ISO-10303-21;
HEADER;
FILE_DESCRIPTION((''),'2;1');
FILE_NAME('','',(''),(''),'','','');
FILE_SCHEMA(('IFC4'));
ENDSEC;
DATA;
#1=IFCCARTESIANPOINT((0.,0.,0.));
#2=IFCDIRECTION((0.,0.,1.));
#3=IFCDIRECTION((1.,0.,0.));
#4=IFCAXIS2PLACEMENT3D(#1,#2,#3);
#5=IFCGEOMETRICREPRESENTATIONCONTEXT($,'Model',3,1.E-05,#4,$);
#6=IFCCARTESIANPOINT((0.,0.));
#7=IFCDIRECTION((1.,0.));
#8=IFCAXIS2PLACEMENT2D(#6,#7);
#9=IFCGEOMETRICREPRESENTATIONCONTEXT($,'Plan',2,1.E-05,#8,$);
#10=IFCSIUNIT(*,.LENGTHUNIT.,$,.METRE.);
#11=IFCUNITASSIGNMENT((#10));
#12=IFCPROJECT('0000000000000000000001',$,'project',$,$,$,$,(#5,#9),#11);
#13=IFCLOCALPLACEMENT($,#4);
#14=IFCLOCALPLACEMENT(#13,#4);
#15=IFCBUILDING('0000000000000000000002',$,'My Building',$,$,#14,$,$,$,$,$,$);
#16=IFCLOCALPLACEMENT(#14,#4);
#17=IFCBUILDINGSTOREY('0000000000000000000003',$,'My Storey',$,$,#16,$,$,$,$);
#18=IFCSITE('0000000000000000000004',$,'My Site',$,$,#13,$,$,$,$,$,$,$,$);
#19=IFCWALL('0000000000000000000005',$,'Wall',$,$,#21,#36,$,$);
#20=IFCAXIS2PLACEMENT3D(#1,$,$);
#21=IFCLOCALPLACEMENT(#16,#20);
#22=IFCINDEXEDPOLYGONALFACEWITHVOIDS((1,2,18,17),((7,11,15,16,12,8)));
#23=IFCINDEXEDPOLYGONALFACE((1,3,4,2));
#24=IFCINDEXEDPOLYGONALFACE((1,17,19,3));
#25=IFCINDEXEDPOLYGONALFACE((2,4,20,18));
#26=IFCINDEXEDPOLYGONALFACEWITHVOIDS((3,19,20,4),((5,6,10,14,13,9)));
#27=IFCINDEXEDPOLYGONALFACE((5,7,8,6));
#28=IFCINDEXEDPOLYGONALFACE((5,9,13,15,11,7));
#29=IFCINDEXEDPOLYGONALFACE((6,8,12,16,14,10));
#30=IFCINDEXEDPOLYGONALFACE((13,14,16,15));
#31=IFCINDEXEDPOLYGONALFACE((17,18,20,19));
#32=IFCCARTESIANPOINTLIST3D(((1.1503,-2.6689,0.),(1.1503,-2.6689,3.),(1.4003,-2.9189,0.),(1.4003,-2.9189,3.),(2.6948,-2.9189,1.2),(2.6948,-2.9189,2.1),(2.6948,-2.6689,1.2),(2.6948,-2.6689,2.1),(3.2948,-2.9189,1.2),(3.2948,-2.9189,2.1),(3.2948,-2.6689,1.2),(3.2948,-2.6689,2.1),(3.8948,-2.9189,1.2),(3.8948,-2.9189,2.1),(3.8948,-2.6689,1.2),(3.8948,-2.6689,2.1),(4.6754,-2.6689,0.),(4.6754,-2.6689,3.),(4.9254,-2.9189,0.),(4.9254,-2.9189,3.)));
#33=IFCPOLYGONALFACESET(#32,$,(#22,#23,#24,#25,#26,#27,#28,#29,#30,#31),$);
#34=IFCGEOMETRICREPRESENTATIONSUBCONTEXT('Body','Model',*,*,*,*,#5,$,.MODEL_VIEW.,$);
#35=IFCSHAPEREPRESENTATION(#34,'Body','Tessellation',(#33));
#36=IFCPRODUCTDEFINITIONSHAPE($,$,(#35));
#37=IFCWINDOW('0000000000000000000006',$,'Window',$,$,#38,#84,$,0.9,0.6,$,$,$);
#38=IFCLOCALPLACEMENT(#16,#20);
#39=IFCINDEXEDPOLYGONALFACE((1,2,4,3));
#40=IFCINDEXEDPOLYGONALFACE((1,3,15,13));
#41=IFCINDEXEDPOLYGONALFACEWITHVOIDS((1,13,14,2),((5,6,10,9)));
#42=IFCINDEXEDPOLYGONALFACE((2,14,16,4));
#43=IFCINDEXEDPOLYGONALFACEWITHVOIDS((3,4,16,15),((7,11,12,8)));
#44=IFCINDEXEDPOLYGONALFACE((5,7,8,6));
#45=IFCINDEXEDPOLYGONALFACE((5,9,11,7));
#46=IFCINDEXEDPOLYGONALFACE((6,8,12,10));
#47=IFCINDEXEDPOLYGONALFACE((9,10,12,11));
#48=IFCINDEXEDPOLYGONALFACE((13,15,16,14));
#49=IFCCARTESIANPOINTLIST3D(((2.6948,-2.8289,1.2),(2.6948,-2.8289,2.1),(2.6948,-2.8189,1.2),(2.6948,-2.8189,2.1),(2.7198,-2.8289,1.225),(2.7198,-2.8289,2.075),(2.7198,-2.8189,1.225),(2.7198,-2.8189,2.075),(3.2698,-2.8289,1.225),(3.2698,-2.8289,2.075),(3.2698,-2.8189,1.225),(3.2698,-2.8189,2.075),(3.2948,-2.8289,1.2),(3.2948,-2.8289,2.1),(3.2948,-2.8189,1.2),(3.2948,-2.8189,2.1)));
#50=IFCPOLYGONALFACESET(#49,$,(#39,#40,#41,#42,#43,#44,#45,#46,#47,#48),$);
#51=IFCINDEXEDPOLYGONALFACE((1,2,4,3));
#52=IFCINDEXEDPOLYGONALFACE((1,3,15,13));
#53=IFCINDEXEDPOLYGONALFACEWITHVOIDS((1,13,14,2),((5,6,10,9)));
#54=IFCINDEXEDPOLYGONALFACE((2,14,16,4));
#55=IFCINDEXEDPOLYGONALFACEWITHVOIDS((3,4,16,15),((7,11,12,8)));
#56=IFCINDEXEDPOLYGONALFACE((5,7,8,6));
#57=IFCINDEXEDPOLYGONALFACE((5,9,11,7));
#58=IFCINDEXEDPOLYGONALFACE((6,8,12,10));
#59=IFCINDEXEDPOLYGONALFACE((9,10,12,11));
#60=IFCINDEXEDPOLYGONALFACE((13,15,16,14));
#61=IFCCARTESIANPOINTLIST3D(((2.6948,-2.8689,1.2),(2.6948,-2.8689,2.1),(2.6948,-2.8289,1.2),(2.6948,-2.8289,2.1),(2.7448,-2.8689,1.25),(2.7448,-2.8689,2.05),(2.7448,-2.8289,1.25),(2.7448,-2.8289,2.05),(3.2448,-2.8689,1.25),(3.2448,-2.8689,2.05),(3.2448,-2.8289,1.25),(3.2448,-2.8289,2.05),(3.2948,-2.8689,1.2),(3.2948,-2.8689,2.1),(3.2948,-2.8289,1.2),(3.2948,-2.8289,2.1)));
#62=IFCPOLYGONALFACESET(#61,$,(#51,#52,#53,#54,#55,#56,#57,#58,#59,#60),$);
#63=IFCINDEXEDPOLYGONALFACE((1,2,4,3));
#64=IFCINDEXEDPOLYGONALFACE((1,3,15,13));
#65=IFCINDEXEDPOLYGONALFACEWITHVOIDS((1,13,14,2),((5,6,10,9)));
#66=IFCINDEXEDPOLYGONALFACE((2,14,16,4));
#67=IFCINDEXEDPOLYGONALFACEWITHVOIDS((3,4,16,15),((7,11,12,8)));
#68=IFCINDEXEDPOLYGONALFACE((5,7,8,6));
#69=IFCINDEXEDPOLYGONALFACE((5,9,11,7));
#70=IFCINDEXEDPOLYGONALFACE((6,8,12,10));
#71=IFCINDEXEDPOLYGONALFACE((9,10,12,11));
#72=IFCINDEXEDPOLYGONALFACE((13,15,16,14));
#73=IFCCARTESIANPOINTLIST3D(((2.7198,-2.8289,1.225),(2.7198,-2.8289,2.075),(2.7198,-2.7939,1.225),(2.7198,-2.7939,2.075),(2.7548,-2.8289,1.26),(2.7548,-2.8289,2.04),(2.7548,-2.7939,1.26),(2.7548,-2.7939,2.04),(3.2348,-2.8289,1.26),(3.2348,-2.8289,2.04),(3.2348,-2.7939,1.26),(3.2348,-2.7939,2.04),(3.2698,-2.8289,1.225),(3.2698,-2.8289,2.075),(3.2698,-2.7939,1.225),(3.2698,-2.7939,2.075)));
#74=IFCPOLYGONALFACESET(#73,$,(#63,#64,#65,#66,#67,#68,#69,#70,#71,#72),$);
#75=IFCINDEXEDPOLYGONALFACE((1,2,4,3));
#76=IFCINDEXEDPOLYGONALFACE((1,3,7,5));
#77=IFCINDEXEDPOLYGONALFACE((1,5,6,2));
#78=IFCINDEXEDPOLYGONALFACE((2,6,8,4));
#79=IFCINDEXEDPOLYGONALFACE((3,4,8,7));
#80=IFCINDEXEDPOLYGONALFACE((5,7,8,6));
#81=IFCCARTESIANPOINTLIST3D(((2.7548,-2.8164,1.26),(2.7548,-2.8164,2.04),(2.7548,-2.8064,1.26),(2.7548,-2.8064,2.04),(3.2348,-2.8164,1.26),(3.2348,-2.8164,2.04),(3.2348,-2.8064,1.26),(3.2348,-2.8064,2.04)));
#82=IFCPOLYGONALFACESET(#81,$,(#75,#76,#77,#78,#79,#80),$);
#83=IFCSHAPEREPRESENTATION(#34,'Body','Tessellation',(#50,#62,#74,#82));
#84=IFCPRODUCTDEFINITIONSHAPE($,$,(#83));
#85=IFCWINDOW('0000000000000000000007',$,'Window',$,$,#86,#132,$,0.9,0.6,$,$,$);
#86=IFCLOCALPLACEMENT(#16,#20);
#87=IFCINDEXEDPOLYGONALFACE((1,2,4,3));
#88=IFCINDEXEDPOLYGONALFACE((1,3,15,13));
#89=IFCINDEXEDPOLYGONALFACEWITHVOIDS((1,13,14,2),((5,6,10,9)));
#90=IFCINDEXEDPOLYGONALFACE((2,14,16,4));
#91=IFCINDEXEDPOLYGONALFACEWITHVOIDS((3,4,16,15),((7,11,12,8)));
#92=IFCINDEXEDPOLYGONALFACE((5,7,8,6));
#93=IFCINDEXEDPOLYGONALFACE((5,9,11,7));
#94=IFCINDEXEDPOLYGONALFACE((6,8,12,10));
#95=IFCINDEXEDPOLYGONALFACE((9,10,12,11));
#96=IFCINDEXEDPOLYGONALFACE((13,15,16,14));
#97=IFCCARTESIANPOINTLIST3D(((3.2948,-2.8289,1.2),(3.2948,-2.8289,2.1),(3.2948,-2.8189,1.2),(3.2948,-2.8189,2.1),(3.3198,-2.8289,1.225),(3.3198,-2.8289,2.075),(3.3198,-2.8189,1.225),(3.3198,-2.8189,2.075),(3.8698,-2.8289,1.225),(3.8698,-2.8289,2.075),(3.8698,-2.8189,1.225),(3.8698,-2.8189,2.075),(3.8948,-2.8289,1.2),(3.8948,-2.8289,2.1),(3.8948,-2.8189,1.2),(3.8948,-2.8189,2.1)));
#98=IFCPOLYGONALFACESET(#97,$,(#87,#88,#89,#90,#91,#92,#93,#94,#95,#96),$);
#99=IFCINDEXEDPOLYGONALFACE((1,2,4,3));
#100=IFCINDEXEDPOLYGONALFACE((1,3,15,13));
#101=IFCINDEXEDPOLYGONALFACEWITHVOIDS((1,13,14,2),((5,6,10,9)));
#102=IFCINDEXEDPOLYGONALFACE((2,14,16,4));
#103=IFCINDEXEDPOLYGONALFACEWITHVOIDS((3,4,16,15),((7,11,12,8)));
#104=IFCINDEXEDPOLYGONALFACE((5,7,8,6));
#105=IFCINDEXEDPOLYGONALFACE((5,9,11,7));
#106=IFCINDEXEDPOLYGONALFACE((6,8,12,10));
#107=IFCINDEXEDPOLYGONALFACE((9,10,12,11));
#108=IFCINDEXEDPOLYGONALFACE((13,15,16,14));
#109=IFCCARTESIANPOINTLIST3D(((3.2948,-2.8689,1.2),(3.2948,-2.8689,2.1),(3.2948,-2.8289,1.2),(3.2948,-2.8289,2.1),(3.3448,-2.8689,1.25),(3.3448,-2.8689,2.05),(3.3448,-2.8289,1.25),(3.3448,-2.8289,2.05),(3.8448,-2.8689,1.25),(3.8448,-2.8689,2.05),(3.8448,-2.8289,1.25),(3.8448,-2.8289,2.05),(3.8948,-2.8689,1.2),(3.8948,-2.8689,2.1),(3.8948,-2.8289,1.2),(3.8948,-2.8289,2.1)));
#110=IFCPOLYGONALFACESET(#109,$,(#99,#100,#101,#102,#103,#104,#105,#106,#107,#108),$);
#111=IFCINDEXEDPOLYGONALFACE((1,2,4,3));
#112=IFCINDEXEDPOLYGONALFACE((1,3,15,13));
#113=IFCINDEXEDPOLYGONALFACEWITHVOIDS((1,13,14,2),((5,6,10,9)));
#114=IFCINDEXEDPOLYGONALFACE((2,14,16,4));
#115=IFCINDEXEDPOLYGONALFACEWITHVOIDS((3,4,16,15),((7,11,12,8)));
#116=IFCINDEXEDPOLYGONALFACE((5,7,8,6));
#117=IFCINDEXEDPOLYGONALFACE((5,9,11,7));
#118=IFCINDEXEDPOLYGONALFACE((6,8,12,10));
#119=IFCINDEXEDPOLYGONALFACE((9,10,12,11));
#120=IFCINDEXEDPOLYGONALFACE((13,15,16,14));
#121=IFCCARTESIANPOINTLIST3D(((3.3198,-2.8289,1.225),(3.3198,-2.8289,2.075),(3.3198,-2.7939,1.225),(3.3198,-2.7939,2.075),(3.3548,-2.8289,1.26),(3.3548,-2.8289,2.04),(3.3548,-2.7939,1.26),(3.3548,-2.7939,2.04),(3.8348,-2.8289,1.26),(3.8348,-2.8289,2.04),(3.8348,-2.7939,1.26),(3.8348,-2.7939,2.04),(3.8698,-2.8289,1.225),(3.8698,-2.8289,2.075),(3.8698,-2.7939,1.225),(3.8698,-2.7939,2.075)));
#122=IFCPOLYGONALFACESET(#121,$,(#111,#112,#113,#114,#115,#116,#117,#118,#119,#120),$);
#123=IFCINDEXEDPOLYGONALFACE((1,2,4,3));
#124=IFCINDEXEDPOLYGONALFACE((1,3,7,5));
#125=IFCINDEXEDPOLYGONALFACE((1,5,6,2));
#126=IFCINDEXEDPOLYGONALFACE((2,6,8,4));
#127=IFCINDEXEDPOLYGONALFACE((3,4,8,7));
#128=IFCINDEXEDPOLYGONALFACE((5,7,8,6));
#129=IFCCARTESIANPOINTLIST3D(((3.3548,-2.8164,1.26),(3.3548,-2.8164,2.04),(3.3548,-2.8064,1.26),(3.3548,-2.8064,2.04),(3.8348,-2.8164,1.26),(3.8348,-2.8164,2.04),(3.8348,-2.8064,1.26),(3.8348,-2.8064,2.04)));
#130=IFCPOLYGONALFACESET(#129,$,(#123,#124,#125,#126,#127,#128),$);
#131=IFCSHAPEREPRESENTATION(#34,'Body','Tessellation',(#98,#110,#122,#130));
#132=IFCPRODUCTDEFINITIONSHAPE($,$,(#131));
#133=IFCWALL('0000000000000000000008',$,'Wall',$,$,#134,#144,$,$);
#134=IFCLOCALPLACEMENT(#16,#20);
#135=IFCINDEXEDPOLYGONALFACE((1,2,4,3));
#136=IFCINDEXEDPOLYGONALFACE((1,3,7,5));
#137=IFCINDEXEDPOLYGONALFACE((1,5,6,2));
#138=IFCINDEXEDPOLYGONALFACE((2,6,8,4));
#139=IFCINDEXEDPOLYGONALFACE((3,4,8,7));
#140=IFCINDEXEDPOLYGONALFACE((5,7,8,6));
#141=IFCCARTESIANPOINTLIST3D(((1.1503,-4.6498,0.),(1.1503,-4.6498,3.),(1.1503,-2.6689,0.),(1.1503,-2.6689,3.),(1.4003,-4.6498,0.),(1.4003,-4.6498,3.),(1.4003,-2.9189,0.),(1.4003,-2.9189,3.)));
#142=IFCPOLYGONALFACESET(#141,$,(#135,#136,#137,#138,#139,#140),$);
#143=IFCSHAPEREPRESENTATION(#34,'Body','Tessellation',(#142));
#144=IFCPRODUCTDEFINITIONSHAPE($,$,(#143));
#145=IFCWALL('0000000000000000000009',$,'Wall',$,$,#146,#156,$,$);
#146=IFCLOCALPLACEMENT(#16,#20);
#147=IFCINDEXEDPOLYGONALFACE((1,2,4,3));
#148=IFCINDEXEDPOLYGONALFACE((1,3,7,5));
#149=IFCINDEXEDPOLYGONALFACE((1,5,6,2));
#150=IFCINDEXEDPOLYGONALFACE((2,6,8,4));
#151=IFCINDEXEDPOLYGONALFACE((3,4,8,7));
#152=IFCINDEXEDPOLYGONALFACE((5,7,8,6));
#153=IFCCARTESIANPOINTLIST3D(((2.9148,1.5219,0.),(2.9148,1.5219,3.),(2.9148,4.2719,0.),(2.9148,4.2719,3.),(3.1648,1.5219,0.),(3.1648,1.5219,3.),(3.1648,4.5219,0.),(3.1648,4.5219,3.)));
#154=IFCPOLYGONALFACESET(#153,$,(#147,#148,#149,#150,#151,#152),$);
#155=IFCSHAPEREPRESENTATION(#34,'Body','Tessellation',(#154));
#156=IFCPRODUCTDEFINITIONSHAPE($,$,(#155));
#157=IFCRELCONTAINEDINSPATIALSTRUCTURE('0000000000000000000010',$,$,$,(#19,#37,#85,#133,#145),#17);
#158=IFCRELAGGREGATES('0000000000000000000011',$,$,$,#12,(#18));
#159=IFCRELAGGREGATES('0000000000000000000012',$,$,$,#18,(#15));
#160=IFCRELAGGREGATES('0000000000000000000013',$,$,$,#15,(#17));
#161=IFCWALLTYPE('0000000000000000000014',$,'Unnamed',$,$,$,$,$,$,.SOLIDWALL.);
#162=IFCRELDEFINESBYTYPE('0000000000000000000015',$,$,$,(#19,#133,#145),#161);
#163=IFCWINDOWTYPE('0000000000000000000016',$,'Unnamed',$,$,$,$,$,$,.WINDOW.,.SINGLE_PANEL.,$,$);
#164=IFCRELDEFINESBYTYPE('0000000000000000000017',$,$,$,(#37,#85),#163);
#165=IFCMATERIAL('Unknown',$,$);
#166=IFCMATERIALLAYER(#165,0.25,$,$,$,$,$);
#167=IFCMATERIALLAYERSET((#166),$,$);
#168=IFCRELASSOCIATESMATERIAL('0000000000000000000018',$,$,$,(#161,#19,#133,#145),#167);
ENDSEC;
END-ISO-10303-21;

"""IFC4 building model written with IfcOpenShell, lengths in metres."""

from ifc_helpers import new_model, entity, si_unit, frame, origin_with_axes, origin_2d_with_axis, place, context, subcontext, project, spatial, line, indexed_curve, outline, extrude, shape, source, transform, mapped, material, layer, layer_set, layer_usage, type_object, type_shapes, element, fill, save


model = new_model("IFC4")

# Units and contexts
model_context = context("Model", 3, precision=1e-05, world=origin_with_axes())
plan_context = context("Plan", 2, precision=1e-05, world=origin_2d_with_axis())
body_context_1 = subcontext(model_context, "Body", "Model", "MODEL_VIEW")
body_context_2 = subcontext(plan_context, "Body", "Plan", "PLAN_VIEW")
ifc_project = project(units=[si_unit("LENGTHUNIT", "METRE")], contexts=[model_context, plan_context])

# Site, building, storey
site_placement = place(None, origin_with_axes())
site = spatial("IfcSite", under=ifc_project, at=site_placement, Name="My Site")
building_placement = place(site_placement, origin_with_axes())
building = spatial("IfcBuilding", under=site, at=building_placement, Name="My Building")
storey_placement = place(building_placement, origin_with_axes())
storey = spatial("IfcBuildingStorey", under=building, at=storey_placement, Name="My Storey")

# Shared definitions
ifc_material = material(Name="Unknown")

# Wall, openings, windows
ifc_layer_1 = layer(ifc_material, 0.25)
ifc_layer_set_1 = layer_set([ifc_layer_1])
wall_type_1 = type_object("IfcWallType", Name="Unnamed", PredefinedType="SOLIDWALL", material=ifc_layer_set_1)
shared_shape_1 = source(origin_with_axes(), body_context_1, "Body", "SweptSolid", [
    extrude(outline(indexed_curve([(0.0, 0.0), (0.6, 0.0), (0.6, 0.9), (0.0, 0.9)], segments=[line(1, 2, 3, 4, 1)])), frame((0.0, -0.6, 0.0), z_axis=(0.0, -1.0, 0.0), x_axis=(1.0, 0.0, 0.0)), (0.0, 0.0, -1.0), 1.2),
])
window_type = type_object("IfcWindowType", Name="Unnamed", PartitioningType="SINGLE_PANEL", PredefinedType="WINDOW")
shared_shape_2 = source(origin_with_axes(), body_context_1, "Body", "SweptSolid", [
    extrude(outline(indexed_curve([(0.0, 0.0), (0.6, 0.0), (0.6, 0.9), (0.0, 0.9)], segments=[line(1, 2, 3, 4, 1)]), holes=[indexed_curve([(0.025, 0.025), (0.575, 0.025), (0.575, 0.875), (0.025, 0.875)], segments=[line(1, 2, 3, 4, 1)])]), frame((0.0, 0.09, 0.0), z_axis=(0.0, -1.0, 0.0), x_axis=(1.0, 0.0, 0.0)), (0.0, 0.0, -1.0), 0.01),
    extrude(outline(indexed_curve([(0.0, 0.0), (0.6, 0.0), (0.6, 0.9), (0.0, 0.9)], segments=[line(1, 2, 3, 4, 1)]), holes=[indexed_curve([(0.05, 0.05), (0.55, 0.05), (0.55, 0.85), (0.05, 0.85)], segments=[line(1, 2, 3, 4, 1)])]), frame((0.0, 0.05, 0.0), z_axis=(0.0, -1.0, 0.0), x_axis=(1.0, 0.0, 0.0)), (0.0, 0.0, -1.0), 0.04),
    extrude(outline(indexed_curve([(0.0, 0.0), (0.55, 0.0), (0.55, 0.85), (0.0, 0.85)], segments=[line(1, 2, 3, 4, 1)]), holes=[indexed_curve([(0.035, 0.035), (0.515, 0.035), (0.515, 0.815), (0.035, 0.815)], segments=[line(1, 2, 3, 4, 1)])]), frame((0.025, 0.09, 0.025), z_axis=(0.0, -1.0, 0.0), x_axis=(1.0, 0.0, 0.0)), (0.0, 0.0, -1.0), 0.035),
    extrude(outline(indexed_curve([(0.035, 0.035), (0.515, 0.035), (0.515, 0.815), (0.035, 0.815)], segments=[line(1, 2, 3, 4, 1)])), frame((0.025, 0.1025, 0.025), z_axis=(0.0, -1.0, 0.0), x_axis=(1.0, 0.0, 0.0)), (0.0, 0.0, -1.0), 0.01),
])
shared_shape_3 = source(origin_with_axes(), body_context_2, "Body", "Curve2D", [
    entity("IfcIndexedPolyCurve", entity("IfcCartesianPointList2D", [[0.05, 0.05], [0.55, 0.05]])),
    entity("IfcIndexedPolyCurve", entity("IfcCartesianPointList2D", [[0.0, 0.1], [0.025, 0.1], [0.025, 0.09], [0.05, 0.09], [0.05, 0.05], [0.0, 0.05]]), [entity("IfcLineIndex", [1, 2, 3, 4, 5, 6, 1])]),
    entity("IfcIndexedPolyCurve", entity("IfcCartesianPointList2D", [[0.6, 0.1], [0.575, 0.1], [0.575, 0.09], [0.55, 0.09], [0.55, 0.05], [0.6, 0.05]]), [entity("IfcLineIndex", [1, 2, 3, 4, 5, 6, 1])]),
    entity("IfcIndexedPolyCurve", entity("IfcCartesianPointList2D", [[0.025, 0.09], [0.06, 0.09], [0.06, 0.125], [0.025, 0.125]]), [entity("IfcLineIndex", [1, 2, 3, 4, 1])]),
    entity("IfcIndexedPolyCurve", entity("IfcCartesianPointList2D", [[0.575, 0.09], [0.54, 0.09], [0.54, 0.125], [0.575, 0.125]]), [entity("IfcLineIndex", [1, 2, 3, 4, 1])]),
    entity("IfcIndexedPolyCurve", entity("IfcCartesianPointList2D", [[0.06, 0.09], [0.54, 0.09]])),
    entity("IfcIndexedPolyCurve", entity("IfcCartesianPointList2D", [[0.06, 0.125], [0.54, 0.125]])),
    entity("IfcIndexedPolyCurve", entity("IfcCartesianPointList2D", [[0.06, 0.1075], [0.54, 0.1075]])),
])
type_shapes(window_type, [shared_shape_2, shared_shape_3])
ifc_layer_usage_1 = layer_usage(ifc_layer_set_1, "AXIS2", "POSITIVE", 0.0)
wall_1_placement = place(storey_placement, frame((4.6754, -2.6689, 0.0), z_axis=(0.0, 0.0, 1.0), x_axis=(-1.0, 0.0, 0.0)))
wall_1 = element("IfcWall", 1, at=wall_1_placement, inside=storey, type_object=wall_type_1, material=ifc_layer_usage_1, Name="Wall", context=body_context_1, shape_type="SweptSolid", body=[
    extrude(outline(indexed_curve([(0.0, 0.0), (-0.25, 0.25), (3.2751, 0.25), (3.5251, 0.0)], segments=[line(1, 2, 3, 4, 1)])), origin_with_axes(), (0.0, 0.0, 1.0), 3.0),
])
opening_1_placement = place(wall_1_placement, frame((1.9806, 0.25, 1.2), z_axis=(0.0, 0.0, 1.0), x_axis=(-1.0, 0.0, 0.0)))
opening_1 = element("IfcOpeningElement", 2, at=opening_1_placement, cuts=wall_1, PredefinedType="OPENING", context=body_context_1, shape_type="MappedRepresentation", body=[
    mapped(shared_shape_1, transform((0.0, 0.0, 0.0), x_axis=(1.0, 0.0, 0.0), y_axis=(0.0, 1.0, 0.0), z_axis=(0.0, 0.0, 1.0), scale=1.0)),
])
opening_2_placement = place(wall_1_placement, frame((1.3806, 0.25, 1.2), z_axis=(0.0, 0.0, 1.0), x_axis=(-1.0, 0.0, 0.0)))
opening_2 = element("IfcOpeningElement", 3, at=opening_2_placement, cuts=wall_1, PredefinedType="OPENING", context=body_context_1, shape_type="MappedRepresentation", body=[
    mapped(shared_shape_1, transform((0.0, 0.0, 0.0), x_axis=(1.0, 0.0, 0.0), y_axis=(0.0, 1.0, 0.0), z_axis=(0.0, 0.0, 1.0), scale=1.0)),
])
window_1_placement = place(opening_1_placement, frame((0.0, 0.0, 0.0), z_axis=(0.0, 0.0, 1.0), x_axis=(1.0, 0.0, 0.0)))
window_1 = element("IfcWindow", 4, at=window_1_placement, inside=storey, type_object=window_type, Name="Window", OverallHeight=0.9, OverallWidth=0.6, shapes=[
    shape(body_context_1, "Body", "MappedRepresentation", [mapped(shared_shape_2, transform((0.0, 0.0, 0.0), x_axis=(1.0, 0.0, 0.0), y_axis=(0.0, 1.0, 0.0), z_axis=(0.0, 0.0, 1.0), scale=1.0))]),
    shape(body_context_2, "Body", "MappedRepresentation", [mapped(shared_shape_3, transform((0.0, 0.0, 0.0), x_axis=(1.0, 0.0, 0.0), y_axis=(0.0, 1.0, 0.0), z_axis=(0.0, 0.0, 1.0), scale=1.0))]),
])
fill(opening_1, window_1)
window_2_placement = place(opening_2_placement, frame((0.0, 0.0, 0.0), z_axis=(0.0, 0.0, 1.0), x_axis=(1.0, 0.0, 0.0)))
window_2 = element("IfcWindow", 5, at=window_2_placement, inside=storey, type_object=window_type, Name="Window", OverallHeight=0.9, OverallWidth=0.6, shapes=[
    shape(body_context_1, "Body", "MappedRepresentation", [mapped(shared_shape_2, transform((0.0, 0.0, 0.0), x_axis=(1.0, 0.0, 0.0), y_axis=(0.0, 1.0, 0.0), z_axis=(0.0, 0.0, 1.0), scale=1.0))]),
    shape(body_context_2, "Body", "MappedRepresentation", [mapped(shared_shape_3, transform((0.0, 0.0, 0.0), x_axis=(1.0, 0.0, 0.0), y_axis=(0.0, 1.0, 0.0), z_axis=(0.0, 0.0, 1.0), scale=1.0))]),
])
fill(opening_2, window_2)

# Walls
ifc_layer_usage_2 = layer_usage(ifc_layer_set_1, "AXIS2", "POSITIVE", 0.0)
wall_2_placement = place(storey_placement, frame((1.1503, -2.6689, 0.0), z_axis=(0.0, 0.0, 1.0), x_axis=(0.0, -1.0, 0.0)))
element("IfcWall", 6, at=wall_2_placement, inside=storey, type_object=wall_type_1, material=ifc_layer_usage_2, Name="Wall", context=body_context_1, shape_type="SweptSolid", body=[
    extrude(outline(indexed_curve([(0.0, 0.0), (0.25, 0.25), (1.9809, 0.25), (1.9809, 0.0)], segments=[line(1, 2, 3, 4, 1)])), origin_with_axes(), (0.0, 0.0, 1.0), 3.0),
])
ifc_layer_usage_3 = layer_usage(ifc_layer_set_1, "AXIS2", "POSITIVE", 0.0)
wall_3_placement = place(storey_placement, frame((3.1648, 1.5219, 0.0), z_axis=(0.0, 0.0, 1.0), x_axis=(0.0, 1.0, 0.0)))
element("IfcWall", 7, at=wall_3_placement, inside=storey, type_object=wall_type_1, material=ifc_layer_usage_3, Name="Wall", context=body_context_1, shape_type="SweptSolid", body=[
    extrude(outline(indexed_curve([(0.0, 0.0), (0.0, 0.25), (2.75, 0.25), (3.0, 0.0)], segments=[line(1, 2, 3, 4, 1)])), origin_with_axes(), (0.0, 0.0, 1.0), 3.0),
])

save(model, "model.ifc")
